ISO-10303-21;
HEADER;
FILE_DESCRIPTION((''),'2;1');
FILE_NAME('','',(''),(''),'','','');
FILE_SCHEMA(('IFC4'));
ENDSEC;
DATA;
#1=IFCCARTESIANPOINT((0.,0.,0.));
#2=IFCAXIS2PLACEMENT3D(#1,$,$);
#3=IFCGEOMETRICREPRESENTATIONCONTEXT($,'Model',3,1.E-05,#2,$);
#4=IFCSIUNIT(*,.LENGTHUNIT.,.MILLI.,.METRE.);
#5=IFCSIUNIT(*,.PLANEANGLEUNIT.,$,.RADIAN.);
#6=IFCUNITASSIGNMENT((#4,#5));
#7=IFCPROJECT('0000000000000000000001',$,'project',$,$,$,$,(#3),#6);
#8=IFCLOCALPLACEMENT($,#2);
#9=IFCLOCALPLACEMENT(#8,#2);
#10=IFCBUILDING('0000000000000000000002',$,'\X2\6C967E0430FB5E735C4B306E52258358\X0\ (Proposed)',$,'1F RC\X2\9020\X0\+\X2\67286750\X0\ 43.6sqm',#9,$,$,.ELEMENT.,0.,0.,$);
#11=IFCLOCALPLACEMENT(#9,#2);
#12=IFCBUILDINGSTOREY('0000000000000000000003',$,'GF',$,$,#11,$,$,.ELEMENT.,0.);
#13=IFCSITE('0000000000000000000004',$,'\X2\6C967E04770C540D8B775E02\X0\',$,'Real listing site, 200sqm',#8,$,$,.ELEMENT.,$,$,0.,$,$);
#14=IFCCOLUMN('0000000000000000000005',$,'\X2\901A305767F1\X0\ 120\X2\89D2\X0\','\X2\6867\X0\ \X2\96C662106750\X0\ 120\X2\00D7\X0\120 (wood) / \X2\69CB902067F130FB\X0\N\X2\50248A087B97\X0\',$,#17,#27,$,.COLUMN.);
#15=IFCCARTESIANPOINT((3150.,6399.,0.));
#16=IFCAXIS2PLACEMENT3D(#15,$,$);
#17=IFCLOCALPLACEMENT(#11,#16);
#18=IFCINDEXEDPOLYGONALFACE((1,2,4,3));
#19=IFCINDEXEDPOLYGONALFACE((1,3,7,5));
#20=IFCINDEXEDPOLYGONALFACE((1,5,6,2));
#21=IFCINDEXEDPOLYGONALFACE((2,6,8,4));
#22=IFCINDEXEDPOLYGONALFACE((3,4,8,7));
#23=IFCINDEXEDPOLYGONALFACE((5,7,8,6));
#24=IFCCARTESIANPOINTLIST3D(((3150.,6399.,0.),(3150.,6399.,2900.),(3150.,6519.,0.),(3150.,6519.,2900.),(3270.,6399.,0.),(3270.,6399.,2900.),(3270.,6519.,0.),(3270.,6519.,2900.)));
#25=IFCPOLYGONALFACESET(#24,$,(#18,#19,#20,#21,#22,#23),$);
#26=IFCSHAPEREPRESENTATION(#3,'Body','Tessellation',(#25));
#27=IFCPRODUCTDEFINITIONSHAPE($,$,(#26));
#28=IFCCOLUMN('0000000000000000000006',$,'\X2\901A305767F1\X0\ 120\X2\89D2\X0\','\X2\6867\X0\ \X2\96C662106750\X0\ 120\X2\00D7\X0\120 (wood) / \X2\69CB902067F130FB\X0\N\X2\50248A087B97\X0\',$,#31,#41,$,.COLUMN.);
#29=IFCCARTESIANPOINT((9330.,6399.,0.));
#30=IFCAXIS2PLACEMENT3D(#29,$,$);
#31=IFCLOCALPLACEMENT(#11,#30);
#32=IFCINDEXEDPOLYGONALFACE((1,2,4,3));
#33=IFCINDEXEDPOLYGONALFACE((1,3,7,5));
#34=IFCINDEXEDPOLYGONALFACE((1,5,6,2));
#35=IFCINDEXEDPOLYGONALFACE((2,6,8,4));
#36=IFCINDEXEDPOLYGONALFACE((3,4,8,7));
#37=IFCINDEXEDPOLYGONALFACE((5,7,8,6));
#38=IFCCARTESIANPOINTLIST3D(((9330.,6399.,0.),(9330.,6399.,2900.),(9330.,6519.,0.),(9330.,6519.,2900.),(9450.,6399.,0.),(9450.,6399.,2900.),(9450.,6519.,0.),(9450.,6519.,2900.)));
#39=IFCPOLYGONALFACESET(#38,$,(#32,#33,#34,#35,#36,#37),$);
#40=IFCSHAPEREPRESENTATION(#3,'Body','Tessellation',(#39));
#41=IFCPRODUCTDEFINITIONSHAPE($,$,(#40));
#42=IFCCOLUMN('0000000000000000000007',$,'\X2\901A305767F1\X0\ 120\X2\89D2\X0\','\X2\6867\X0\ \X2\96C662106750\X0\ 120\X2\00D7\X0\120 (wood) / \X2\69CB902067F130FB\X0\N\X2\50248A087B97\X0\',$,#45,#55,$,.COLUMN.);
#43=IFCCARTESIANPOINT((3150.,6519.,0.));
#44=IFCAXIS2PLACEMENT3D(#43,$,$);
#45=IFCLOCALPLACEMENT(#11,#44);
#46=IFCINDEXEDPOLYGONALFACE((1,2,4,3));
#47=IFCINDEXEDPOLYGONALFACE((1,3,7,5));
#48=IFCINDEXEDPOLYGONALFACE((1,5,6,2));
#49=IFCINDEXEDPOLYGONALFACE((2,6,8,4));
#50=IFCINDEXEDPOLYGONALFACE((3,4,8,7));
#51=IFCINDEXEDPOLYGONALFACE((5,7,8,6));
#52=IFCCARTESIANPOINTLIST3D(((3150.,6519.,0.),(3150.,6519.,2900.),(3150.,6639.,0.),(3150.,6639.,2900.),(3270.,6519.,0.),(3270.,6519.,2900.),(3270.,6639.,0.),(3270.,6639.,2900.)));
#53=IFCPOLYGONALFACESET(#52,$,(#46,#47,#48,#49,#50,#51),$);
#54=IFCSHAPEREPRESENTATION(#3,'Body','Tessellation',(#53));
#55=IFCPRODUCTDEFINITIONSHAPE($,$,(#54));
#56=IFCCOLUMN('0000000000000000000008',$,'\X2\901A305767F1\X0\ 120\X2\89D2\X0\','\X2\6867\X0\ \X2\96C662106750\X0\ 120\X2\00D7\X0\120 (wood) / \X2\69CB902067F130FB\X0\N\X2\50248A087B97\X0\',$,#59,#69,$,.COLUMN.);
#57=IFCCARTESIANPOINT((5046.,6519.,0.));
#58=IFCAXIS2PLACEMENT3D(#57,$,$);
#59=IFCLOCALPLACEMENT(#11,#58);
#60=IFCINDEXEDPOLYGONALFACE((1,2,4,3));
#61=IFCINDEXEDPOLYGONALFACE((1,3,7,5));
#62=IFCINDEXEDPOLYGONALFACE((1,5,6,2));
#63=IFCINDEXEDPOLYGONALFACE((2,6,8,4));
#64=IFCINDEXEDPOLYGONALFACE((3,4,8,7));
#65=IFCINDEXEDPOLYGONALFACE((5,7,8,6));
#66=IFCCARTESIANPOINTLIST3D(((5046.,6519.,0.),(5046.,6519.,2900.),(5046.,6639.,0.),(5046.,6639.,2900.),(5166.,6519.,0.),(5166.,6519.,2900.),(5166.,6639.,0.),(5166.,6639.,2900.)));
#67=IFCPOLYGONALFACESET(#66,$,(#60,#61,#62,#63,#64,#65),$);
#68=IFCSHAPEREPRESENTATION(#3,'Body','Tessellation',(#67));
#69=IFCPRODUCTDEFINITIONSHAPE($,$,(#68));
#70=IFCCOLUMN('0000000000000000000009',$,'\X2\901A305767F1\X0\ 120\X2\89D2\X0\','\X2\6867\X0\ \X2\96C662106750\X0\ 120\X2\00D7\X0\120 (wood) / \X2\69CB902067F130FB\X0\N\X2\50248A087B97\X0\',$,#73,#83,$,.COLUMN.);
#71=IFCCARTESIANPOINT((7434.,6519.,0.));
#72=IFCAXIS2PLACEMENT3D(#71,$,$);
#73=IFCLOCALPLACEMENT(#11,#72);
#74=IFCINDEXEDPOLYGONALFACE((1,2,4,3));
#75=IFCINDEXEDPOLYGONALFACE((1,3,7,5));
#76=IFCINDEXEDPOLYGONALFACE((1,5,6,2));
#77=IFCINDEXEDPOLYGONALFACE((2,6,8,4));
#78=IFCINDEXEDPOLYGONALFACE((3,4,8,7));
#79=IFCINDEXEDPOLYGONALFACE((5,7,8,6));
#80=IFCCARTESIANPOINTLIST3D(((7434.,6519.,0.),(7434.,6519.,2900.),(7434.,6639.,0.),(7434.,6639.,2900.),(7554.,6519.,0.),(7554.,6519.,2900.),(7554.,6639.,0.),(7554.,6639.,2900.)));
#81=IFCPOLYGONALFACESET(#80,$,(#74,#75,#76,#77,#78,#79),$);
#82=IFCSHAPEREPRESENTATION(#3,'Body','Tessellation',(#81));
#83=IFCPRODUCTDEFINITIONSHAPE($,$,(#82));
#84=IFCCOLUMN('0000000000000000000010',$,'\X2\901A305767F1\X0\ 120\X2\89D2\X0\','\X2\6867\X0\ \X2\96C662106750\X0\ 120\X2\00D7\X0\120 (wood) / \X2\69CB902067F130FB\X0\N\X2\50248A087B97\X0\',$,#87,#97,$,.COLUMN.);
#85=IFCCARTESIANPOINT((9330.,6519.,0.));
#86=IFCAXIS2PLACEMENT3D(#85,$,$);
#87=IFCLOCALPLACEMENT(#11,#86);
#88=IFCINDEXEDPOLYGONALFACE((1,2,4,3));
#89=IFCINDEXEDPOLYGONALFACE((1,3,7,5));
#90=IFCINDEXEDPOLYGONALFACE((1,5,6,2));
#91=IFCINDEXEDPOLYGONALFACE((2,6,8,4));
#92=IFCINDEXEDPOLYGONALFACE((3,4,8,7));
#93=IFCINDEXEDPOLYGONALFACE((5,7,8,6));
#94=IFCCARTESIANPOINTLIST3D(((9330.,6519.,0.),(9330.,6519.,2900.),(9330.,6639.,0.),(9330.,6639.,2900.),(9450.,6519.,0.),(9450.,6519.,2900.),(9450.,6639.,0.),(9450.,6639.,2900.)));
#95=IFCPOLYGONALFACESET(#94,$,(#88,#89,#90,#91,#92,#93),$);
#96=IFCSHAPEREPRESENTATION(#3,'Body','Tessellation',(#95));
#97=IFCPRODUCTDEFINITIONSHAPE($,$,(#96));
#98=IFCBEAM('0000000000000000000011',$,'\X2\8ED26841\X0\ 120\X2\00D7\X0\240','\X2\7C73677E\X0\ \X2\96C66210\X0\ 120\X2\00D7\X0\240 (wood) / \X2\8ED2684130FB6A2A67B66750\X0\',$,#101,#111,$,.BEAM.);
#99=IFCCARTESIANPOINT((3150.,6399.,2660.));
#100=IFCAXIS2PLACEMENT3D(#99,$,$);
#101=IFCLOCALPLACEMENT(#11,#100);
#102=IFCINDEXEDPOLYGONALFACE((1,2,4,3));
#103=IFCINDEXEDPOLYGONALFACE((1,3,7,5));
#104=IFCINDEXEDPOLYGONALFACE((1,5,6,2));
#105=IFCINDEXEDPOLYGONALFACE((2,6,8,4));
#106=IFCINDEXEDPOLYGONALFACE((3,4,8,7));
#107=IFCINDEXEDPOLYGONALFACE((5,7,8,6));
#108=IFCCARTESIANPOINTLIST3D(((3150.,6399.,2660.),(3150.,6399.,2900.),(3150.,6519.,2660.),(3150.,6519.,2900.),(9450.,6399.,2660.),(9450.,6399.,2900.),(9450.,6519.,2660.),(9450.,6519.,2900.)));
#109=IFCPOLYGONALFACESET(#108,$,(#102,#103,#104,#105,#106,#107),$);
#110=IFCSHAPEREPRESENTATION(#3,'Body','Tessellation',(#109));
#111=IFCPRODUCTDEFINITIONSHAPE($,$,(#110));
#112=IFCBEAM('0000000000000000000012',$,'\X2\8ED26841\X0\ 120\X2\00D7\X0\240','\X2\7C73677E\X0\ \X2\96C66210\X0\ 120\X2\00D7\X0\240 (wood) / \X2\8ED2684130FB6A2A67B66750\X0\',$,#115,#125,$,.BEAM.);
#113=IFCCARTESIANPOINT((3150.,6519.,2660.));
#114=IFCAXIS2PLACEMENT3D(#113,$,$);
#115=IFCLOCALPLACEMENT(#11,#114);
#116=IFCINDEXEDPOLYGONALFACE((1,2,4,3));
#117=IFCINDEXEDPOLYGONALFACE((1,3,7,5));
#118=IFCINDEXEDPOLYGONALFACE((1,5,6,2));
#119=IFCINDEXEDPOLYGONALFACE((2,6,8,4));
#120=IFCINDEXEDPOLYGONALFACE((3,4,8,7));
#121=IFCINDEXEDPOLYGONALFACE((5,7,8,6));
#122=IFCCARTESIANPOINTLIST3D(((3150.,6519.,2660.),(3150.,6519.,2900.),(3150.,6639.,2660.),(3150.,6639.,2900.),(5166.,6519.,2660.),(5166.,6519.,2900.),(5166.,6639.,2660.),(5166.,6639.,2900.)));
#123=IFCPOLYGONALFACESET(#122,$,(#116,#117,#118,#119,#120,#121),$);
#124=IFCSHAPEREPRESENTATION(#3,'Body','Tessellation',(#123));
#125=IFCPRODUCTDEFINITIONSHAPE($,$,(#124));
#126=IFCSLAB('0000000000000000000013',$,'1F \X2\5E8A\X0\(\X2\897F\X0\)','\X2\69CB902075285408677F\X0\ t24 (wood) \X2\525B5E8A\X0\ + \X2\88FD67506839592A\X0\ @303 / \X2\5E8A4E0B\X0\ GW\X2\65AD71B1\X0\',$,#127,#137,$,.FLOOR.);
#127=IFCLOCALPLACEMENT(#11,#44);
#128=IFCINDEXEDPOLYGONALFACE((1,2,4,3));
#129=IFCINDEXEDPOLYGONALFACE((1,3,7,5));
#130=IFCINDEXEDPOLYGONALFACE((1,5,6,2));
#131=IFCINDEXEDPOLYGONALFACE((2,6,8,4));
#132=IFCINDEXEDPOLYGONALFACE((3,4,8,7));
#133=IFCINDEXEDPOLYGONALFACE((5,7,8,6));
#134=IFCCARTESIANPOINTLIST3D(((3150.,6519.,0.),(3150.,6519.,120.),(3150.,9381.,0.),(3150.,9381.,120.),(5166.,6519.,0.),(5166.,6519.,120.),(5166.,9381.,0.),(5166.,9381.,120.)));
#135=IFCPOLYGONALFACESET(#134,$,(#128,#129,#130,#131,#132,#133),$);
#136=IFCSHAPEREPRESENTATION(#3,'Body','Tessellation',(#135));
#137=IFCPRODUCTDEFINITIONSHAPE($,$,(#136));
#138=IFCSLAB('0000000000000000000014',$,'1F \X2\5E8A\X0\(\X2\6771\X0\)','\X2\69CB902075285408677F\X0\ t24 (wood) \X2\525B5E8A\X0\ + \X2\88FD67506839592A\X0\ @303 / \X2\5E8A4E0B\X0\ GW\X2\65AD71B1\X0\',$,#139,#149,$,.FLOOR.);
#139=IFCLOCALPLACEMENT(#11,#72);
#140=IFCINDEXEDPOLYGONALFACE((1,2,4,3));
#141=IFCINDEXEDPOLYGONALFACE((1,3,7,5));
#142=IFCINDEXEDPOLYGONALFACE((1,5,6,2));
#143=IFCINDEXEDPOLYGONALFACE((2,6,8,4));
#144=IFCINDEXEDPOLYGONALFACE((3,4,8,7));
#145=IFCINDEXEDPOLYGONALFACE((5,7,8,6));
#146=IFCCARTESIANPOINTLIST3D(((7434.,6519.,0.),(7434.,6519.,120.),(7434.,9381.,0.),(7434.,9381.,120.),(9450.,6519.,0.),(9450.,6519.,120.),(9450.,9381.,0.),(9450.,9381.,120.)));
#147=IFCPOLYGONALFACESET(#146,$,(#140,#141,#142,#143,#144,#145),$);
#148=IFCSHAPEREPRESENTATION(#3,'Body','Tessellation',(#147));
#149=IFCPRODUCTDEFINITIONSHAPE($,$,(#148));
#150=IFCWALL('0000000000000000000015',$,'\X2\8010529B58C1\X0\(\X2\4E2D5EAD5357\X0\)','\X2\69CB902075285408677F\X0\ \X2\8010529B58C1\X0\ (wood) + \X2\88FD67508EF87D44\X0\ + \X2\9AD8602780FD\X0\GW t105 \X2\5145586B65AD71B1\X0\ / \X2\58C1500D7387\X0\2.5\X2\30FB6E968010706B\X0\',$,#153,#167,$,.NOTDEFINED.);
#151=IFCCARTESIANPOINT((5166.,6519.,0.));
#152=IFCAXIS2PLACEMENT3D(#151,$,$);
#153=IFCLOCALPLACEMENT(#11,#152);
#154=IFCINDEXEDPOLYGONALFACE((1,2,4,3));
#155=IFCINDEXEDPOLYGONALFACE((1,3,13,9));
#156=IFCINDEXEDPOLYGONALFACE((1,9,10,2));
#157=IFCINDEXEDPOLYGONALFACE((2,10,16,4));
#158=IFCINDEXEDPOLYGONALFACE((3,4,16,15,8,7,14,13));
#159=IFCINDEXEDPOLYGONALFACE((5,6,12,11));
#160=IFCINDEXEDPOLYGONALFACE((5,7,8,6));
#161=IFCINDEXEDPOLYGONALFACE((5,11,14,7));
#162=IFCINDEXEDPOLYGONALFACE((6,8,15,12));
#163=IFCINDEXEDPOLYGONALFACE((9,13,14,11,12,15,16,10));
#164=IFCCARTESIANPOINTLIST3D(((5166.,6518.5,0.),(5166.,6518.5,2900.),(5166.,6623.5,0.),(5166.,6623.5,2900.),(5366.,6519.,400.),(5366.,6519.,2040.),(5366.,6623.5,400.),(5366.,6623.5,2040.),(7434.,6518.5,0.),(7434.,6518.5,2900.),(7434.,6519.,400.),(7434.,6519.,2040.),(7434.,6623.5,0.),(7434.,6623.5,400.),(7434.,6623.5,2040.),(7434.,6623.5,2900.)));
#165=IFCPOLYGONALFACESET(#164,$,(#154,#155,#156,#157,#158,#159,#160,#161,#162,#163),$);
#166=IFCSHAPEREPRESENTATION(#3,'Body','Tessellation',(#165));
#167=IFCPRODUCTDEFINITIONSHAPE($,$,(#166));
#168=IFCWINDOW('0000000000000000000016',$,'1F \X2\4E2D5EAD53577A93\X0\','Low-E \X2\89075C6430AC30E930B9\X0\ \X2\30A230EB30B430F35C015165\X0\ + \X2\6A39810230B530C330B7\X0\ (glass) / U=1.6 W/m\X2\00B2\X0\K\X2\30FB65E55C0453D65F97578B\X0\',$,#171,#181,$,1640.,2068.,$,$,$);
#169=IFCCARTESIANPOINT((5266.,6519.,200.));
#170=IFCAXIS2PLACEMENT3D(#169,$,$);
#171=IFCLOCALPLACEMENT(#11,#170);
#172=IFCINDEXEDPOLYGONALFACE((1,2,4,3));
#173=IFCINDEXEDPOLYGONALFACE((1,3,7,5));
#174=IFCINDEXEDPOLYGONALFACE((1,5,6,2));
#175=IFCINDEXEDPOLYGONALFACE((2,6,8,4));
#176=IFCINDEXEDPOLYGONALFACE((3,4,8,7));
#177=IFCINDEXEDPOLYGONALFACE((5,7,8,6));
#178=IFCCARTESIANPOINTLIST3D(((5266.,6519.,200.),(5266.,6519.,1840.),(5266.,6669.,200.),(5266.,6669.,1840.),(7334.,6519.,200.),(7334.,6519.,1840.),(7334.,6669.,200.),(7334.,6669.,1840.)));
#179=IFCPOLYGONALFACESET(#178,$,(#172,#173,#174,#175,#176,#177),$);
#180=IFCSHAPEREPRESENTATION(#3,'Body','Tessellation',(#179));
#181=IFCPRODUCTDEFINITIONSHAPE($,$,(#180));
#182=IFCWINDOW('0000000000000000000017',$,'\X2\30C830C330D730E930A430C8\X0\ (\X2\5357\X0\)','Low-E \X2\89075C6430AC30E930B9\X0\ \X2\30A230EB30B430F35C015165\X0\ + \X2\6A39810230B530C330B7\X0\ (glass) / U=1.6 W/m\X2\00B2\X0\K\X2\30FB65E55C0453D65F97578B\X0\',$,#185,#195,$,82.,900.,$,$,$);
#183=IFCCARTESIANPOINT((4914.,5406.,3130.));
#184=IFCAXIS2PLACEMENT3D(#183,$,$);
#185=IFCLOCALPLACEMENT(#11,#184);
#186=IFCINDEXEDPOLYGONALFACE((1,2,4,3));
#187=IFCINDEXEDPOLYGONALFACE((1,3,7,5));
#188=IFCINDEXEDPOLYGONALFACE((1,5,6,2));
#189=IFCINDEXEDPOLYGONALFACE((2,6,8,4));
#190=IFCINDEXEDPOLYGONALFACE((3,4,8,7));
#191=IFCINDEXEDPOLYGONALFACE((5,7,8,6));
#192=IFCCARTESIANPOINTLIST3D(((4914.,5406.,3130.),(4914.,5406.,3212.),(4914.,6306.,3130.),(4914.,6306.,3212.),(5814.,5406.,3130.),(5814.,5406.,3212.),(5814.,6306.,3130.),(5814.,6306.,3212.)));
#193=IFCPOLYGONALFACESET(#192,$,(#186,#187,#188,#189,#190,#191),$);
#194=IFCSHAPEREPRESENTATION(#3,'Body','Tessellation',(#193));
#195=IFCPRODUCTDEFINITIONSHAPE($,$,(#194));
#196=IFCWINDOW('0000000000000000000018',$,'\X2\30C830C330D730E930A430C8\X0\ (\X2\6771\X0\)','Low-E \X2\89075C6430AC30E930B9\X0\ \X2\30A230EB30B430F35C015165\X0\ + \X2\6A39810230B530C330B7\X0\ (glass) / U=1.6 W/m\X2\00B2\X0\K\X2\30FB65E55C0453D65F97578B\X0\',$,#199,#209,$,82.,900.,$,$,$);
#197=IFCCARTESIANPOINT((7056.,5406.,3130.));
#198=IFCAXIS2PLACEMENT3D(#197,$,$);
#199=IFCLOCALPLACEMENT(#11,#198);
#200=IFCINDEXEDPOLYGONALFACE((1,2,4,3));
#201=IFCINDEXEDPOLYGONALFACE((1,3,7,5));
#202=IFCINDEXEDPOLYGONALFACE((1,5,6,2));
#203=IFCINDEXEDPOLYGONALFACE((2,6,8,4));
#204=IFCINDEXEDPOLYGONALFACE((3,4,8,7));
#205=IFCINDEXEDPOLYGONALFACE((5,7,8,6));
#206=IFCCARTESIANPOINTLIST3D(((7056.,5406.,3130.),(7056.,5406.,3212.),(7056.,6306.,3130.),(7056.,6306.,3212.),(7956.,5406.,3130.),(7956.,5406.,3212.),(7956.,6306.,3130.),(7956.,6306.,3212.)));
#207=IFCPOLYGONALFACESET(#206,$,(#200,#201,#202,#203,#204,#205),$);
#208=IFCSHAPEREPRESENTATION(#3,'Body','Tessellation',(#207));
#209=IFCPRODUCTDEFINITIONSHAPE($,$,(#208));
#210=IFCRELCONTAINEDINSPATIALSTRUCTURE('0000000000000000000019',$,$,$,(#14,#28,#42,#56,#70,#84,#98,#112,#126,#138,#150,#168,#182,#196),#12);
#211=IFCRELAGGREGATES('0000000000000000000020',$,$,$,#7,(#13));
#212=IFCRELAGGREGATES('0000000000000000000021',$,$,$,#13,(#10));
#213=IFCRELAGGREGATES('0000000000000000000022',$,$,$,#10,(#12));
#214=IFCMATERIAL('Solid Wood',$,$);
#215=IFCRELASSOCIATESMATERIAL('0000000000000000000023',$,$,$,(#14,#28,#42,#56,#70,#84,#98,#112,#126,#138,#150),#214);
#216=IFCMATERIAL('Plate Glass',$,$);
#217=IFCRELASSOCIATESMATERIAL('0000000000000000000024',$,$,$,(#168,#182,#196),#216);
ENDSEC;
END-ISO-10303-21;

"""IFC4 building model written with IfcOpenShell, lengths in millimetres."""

from ifc_helpers import new_model, si_unit, frame, frame_2d, origin, place, context, project, spatial, rectangle, extrude, material, element, fill, save


model = new_model("IFC4")

# Units and contexts
model_context = context("Model", 3, precision=1e-05, world=origin())
ifc_project = project(units=[si_unit("LENGTHUNIT", "METRE", prefix="MILLI"), si_unit("PLANEANGLEUNIT", "RADIAN")], contexts=[model_context])

# Site, building, storey
site_placement = place(None, origin())
site = spatial("IfcSite", under=ifc_project, at=site_placement, Name="沖縄県名護市", ObjectType="Real listing site, 200sqm", CompositionType="ELEMENT", RefElevation=0.0)
building_placement = place(site_placement, origin())
building = spatial("IfcBuilding", under=site, at=building_placement, Name="沖縄・平屋の別荘 (Proposed)", ObjectType="1F RC造+木材 43.6sqm", CompositionType="ELEMENT", ElevationOfRefHeight=0.0, ElevationOfTerrain=0.0)
storey_placement = place(building_placement, origin())
storey = spatial("IfcBuildingStorey", under=building, at=storey_placement, Name="GF", CompositionType="ELEMENT", Elevation=0.0)

# Columns
ifc_material_1 = material(Name="Solid Wood")
column_1_placement = place(storey_placement, frame((3150.0, 6399.0, 0.0)))
element("IfcColumn", 1, at=column_1_placement, inside=storey, material=ifc_material_1, Name="通し柱 120角", Description="桧 集成材 120×120 (wood) / 構造柱・N値計算", PredefinedType="COLUMN", context=model_context, shape_type="SweptSolid", body=[
    extrude(rectangle(XDim=120.0, YDim=120.0, at=frame_2d((60.0, 60.0))), frame((3150.0, 6399.0, 0.0)), (0.0, 0.0, 1.0), 2900.0),
])
column_2_placement = place(storey_placement, frame((9330.0, 6399.0, 0.0)))
element("IfcColumn", 2, at=column_2_placement, inside=storey, material=ifc_material_1, Name="通し柱 120角", Description="桧 集成材 120×120 (wood) / 構造柱・N値計算", PredefinedType="COLUMN", context=model_context, shape_type="SweptSolid", body=[
    extrude(rectangle(XDim=120.0, YDim=120.0, at=frame_2d((60.0, 60.0))), frame((9330.0, 6399.0, 0.0)), (0.0, 0.0, 1.0), 2900.0),
])
column_3_placement = place(storey_placement, frame((3150.0, 6519.0, 0.0)))
element("IfcColumn", 3, at=column_3_placement, inside=storey, material=ifc_material_1, Name="通し柱 120角", Description="桧 集成材 120×120 (wood) / 構造柱・N値計算", PredefinedType="COLUMN", context=model_context, shape_type="SweptSolid", body=[
    extrude(rectangle(XDim=120.0, YDim=120.0, at=frame_2d((60.0, 60.0))), frame((3150.0, 6519.0, 0.0)), (0.0, 0.0, 1.0), 2900.0),
])
column_4_placement = place(storey_placement, frame((5046.0, 6519.0, 0.0)))
element("IfcColumn", 4, at=column_4_placement, inside=storey, material=ifc_material_1, Name="通し柱 120角", Description="桧 集成材 120×120 (wood) / 構造柱・N値計算", PredefinedType="COLUMN", context=model_context, shape_type="SweptSolid", body=[
    extrude(rectangle(XDim=120.0, YDim=120.0, at=frame_2d((60.0, 60.0))), frame((5046.0, 6519.0, 0.0)), (0.0, 0.0, 1.0), 2900.0),
])
column_5_placement = place(storey_placement, frame((7434.0, 6519.0, 0.0)))
element("IfcColumn", 5, at=column_5_placement, inside=storey, material=ifc_material_1, Name="通し柱 120角", Description="桧 集成材 120×120 (wood) / 構造柱・N値計算", PredefinedType="COLUMN", context=model_context, shape_type="SweptSolid", body=[
    extrude(rectangle(XDim=120.0, YDim=120.0, at=frame_2d((60.0, 60.0))), frame((7434.0, 6519.0, 0.0)), (0.0, 0.0, 1.0), 2900.0),
])
column_6_placement = place(storey_placement, frame((9330.0, 6519.0, 0.0)))
element("IfcColumn", 6, at=column_6_placement, inside=storey, material=ifc_material_1, Name="通し柱 120角", Description="桧 集成材 120×120 (wood) / 構造柱・N値計算", PredefinedType="COLUMN", context=model_context, shape_type="SweptSolid", body=[
    extrude(rectangle(XDim=120.0, YDim=120.0, at=frame_2d((60.0, 60.0))), frame((9330.0, 6519.0, 0.0)), (0.0, 0.0, 1.0), 2900.0),
])

# Beams
beam_1_placement = place(storey_placement, frame((3150.0, 6399.0, 2660.0)))
element("IfcBeam", 7, at=beam_1_placement, inside=storey, material=ifc_material_1, Name="軒桁 120×240", Description="米松 集成 120×240 (wood) / 軒桁・横架材", PredefinedType="BEAM", context=model_context, shape_type="SweptSolid", body=[
    extrude(rectangle(XDim=6300.0, YDim=120.0, at=frame_2d((3150.0, 60.0))), frame((3150.0, 6399.0, 2660.0)), (0.0, 0.0, 1.0), 240.0),
])
beam_2_placement = place(storey_placement, frame((3150.0, 6519.0, 2660.0)))
element("IfcBeam", 8, at=beam_2_placement, inside=storey, material=ifc_material_1, Name="軒桁 120×240", Description="米松 集成 120×240 (wood) / 軒桁・横架材", PredefinedType="BEAM", context=model_context, shape_type="SweptSolid", body=[
    extrude(rectangle(XDim=2016.0, YDim=120.0, at=frame_2d((1008.0, 60.0))), frame((3150.0, 6519.0, 2660.0)), (0.0, 0.0, 1.0), 240.0),
])

# Slabs
slab_1_placement = place(storey_placement, frame((3150.0, 6519.0, 0.0)))
element("IfcSlab", 9, at=slab_1_placement, inside=storey, material=ifc_material_1, Name="1F 床(西)", Description="構造用合板 t24 (wood) 剛床 + 製材根太 @303 / 床下 GW断熱", PredefinedType="FLOOR", context=model_context, shape_type="SweptSolid", body=[
    extrude(rectangle(XDim=2016.0, YDim=2862.0, at=frame_2d((1008.0, 1431.0))), frame((3150.0, 6519.0, 0.0)), (0.0, 0.0, 1.0), 120.0),
])
slab_2_placement = place(storey_placement, frame((7434.0, 6519.0, 0.0)))
element("IfcSlab", 10, at=slab_2_placement, inside=storey, material=ifc_material_1, Name="1F 床(東)", Description="構造用合板 t24 (wood) 剛床 + 製材根太 @303 / 床下 GW断熱", PredefinedType="FLOOR", context=model_context, shape_type="SweptSolid", body=[
    extrude(rectangle(XDim=2016.0, YDim=2862.0, at=frame_2d((1008.0, 1431.0))), frame((7434.0, 6519.0, 0.0)), (0.0, 0.0, 1.0), 120.0),
])

# Wall, opening, window
wall_1_placement = place(storey_placement, frame((5166.0, 6519.0, 0.0)))
wall_1 = element("IfcWall", 11, at=wall_1_placement, inside=storey, material=ifc_material_1, Name="耐力壁(中庭南)", Description="構造用合板 耐力壁 (wood) + 製材軸組 + 高性能GW t105 充填断熱 / 壁倍率2.5・準耐火", PredefinedType="NOTDEFINED", context=model_context, shape_type="SweptSolid", body=[
    extrude(rectangle(XDim=2268.0, YDim=105.0, at=frame_2d((1134.0, 52.0))), frame((5166.0, 6519.0, 0.0)), (0.0, 0.0, 1.0), 2900.0),
])
opening_placement = place(storey_placement, frame((5266.0, 6519.0, 200.0)))
opening = element("IfcOpeningElement", 12, at=opening_placement, cuts=wall_1, PredefinedType="NOTDEFINED", context=model_context, shape_type="SweptSolid", body=[
    extrude(rectangle(XDim=2068.0, YDim=150.0, at=frame_2d((1034.0, 75.0))), frame((5266.0, 6519.0, 200.0)), (0.0, 0.0, 1.0), 1640.0),
])
ifc_material_2 = material(Name="Plate Glass")
window_1_placement = place(storey_placement, frame((5266.0, 6519.0, 200.0)))
window_1 = element("IfcWindow", 13, at=window_1_placement, inside=storey, material=ifc_material_2, Name="1F 中庭南窓", Description="Low-E 複層ガラス アルゴン封入 + 樹脂サッシ (glass) / U=1.6 W/m²K・日射取得型", OverallHeight=1640.0, OverallWidth=2068.0, context=model_context, shape_type="SweptSolid", body=[
    extrude(rectangle(XDim=2068.0, YDim=150.0, at=frame_2d((1034.0, 75.0))), frame((5266.0, 6519.0, 200.0)), (0.0, 0.0, 1.0), 1640.0),
])
fill(opening, window_1)

# Windows
window_2_placement = place(storey_placement, frame((4914.0, 5406.0, 3130.0)))
element("IfcWindow", 14, at=window_2_placement, inside=storey, material=ifc_material_2, Name="トップライト (南)", Description="Low-E 複層ガラス アルゴン封入 + 樹脂サッシ (glass) / U=1.6 W/m²K・日射取得型", OverallHeight=82.0, OverallWidth=900.0, context=model_context, shape_type="SweptSolid", body=[
    extrude(rectangle(XDim=900.0, YDim=900.0, at=frame_2d((450.0, 450.0))), frame((4914.0, 5406.0, 3130.0)), (0.0, 0.0, 1.0), 82.0),
])
window_3_placement = place(storey_placement, frame((7056.0, 5406.0, 3130.0)))
element("IfcWindow", 15, at=window_3_placement, inside=storey, material=ifc_material_2, Name="トップライト (東)", Description="Low-E 複層ガラス アルゴン封入 + 樹脂サッシ (glass) / U=1.6 W/m²K・日射取得型", OverallHeight=82.0, OverallWidth=900.0, context=model_context, shape_type="SweptSolid", body=[
    extrude(rectangle(XDim=900.0, YDim=900.0, at=frame_2d((450.0, 450.0))), frame((7056.0, 5406.0, 3130.0)), (0.0, 0.0, 1.0), 82.0),
])

save(model, "model.ifc")
